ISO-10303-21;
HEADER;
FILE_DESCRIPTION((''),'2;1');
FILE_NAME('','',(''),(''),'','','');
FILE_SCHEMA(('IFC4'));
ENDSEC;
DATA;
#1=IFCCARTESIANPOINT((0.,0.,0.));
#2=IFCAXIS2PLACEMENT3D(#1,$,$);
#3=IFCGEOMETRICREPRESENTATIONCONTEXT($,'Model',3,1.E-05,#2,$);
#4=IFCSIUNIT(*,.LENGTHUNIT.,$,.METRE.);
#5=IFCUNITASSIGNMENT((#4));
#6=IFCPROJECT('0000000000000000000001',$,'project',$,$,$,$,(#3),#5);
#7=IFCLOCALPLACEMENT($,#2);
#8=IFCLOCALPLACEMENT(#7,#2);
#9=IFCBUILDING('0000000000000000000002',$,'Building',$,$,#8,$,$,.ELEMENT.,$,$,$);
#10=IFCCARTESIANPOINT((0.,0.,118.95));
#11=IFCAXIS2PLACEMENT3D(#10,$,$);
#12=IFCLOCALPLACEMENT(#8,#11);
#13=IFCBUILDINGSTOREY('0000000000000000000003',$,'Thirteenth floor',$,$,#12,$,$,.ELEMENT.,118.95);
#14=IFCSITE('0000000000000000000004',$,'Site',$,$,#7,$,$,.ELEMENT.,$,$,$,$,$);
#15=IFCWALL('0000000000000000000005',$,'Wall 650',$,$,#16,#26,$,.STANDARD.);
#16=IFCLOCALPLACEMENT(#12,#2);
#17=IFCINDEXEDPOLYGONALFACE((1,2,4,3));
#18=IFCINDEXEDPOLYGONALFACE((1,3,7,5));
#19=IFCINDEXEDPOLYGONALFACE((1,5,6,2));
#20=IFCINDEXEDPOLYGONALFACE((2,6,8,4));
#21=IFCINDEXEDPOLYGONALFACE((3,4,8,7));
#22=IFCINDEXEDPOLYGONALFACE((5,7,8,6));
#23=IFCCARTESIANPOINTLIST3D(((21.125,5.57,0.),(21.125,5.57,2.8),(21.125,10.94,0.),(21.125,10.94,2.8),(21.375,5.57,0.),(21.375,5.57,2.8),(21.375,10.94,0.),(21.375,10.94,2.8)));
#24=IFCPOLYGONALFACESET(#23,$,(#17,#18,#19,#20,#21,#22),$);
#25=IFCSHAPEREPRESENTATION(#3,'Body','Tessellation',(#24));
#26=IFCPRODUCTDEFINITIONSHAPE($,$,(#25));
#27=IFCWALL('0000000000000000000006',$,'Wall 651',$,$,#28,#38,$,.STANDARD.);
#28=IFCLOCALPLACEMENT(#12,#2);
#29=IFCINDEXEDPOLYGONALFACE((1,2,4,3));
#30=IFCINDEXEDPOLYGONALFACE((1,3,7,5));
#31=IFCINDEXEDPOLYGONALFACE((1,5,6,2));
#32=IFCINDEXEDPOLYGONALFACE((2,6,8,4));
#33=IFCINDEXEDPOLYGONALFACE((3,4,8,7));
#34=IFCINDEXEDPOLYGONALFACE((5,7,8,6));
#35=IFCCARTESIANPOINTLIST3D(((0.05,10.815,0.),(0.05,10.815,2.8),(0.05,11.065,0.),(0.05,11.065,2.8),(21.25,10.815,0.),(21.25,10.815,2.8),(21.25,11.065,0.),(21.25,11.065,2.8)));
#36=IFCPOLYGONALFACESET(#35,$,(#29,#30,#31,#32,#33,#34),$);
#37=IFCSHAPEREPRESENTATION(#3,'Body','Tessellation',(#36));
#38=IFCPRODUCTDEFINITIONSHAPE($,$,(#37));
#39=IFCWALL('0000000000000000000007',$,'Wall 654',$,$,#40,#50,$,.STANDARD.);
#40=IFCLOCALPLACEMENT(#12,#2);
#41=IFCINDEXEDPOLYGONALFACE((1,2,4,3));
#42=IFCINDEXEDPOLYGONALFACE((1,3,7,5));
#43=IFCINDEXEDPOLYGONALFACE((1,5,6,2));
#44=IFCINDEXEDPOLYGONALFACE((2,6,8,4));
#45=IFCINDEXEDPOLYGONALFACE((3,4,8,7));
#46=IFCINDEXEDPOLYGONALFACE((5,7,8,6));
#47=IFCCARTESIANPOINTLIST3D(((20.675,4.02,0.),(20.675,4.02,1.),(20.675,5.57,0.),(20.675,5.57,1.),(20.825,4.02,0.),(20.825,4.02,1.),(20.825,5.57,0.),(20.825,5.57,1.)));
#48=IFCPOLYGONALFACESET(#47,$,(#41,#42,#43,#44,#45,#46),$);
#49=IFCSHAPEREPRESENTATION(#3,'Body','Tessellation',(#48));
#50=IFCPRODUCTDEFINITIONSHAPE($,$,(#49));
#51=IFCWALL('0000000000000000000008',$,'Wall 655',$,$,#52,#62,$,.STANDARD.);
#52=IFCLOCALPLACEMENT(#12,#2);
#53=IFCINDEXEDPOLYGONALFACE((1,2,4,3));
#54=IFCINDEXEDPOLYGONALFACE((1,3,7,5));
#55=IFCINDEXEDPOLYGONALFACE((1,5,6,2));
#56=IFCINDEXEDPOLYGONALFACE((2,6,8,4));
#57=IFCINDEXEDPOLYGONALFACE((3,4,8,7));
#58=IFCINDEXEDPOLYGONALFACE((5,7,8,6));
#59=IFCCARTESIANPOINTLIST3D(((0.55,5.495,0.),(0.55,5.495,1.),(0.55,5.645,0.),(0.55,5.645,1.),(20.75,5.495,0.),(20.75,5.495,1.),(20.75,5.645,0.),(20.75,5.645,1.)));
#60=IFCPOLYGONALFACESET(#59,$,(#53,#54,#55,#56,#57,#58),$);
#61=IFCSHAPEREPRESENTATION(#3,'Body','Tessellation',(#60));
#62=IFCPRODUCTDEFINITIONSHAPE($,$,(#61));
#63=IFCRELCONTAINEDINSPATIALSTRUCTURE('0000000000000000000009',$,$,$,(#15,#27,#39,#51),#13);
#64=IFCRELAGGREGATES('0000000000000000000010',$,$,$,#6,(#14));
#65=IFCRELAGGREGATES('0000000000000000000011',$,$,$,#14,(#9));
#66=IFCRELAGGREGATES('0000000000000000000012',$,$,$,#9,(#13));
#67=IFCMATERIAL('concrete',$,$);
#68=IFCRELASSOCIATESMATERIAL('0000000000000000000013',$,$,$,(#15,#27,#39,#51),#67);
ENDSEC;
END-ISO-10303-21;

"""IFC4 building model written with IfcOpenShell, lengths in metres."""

from ifc_helpers import new_model, si_unit, frame, frame_2d, origin, place, context, project, spatial, rectangle, extrude, material, element, save


model = new_model("IFC4")

# Units and contexts
model_context = context("Model", 3, precision=1e-05, world=origin())
ifc_project = project(units=[si_unit("LENGTHUNIT", "METRE")], contexts=[model_context])

# Site, building, storey
site_placement = place(None, origin())
site = spatial("IfcSite", under=ifc_project, at=site_placement, Name="Site", CompositionType="ELEMENT")
building_placement = place(site_placement, origin())
building = spatial("IfcBuilding", under=site, at=building_placement, Name="Building", CompositionType="ELEMENT")
storey_placement = place(building_placement, frame((0.0, 0.0, 118.95)))
storey = spatial("IfcBuildingStorey", under=building, at=storey_placement, Name="Thirteenth floor", CompositionType="ELEMENT", Elevation=118.95)

# Walls
ifc_material = material(Name="concrete")
wall_1_placement = place(storey_placement, frame((21.25, 5.57, 0.0), z_axis=(0.0, 0.0, 1.0), x_axis=(0.0, 1.0, 0.0)))
element("IfcWall", 1, at=wall_1_placement, inside=storey, material=ifc_material, Name="Wall 650", PredefinedType="STANDARD", context=model_context, shape_type="SweptSolid", body=[
    extrude(rectangle(XDim=5.37, YDim=0.25, at=frame_2d((2.685, 0.0))), origin(), (0.0, 0.0, 1.0), 2.8),
])
wall_2_placement = place(storey_placement, frame((21.25, 10.94, 0.0), z_axis=(0.0, 0.0, 1.0), x_axis=(-1.0, 0.0, 0.0)))
element("IfcWall", 2, at=wall_2_placement, inside=storey, material=ifc_material, Name="Wall 651", PredefinedType="STANDARD", context=model_context, shape_type="SweptSolid", body=[
    extrude(rectangle(XDim=21.2, YDim=0.25, at=frame_2d((10.6, 0.0))), origin(), (0.0, 0.0, 1.0), 2.8),
])
wall_3_placement = place(storey_placement, frame((20.75, 4.02, 0.0), z_axis=(0.0, 0.0, 1.0), x_axis=(0.0, 1.0, 0.0)))
element("IfcWall", 3, at=wall_3_placement, inside=storey, material=ifc_material, Name="Wall 654", PredefinedType="STANDARD", context=model_context, shape_type="SweptSolid", body=[
    extrude(rectangle(XDim=1.55, YDim=0.15, at=frame_2d((0.775, 0.0))), origin(), (0.0, 0.0, 1.0), 1.0),
])
wall_4_placement = place(storey_placement, frame((20.75, 5.57, 0.0), z_axis=(0.0, 0.0, 1.0), x_axis=(-1.0, 0.0, 0.0)))
element("IfcWall", 4, at=wall_4_placement, inside=storey, material=ifc_material, Name="Wall 655", PredefinedType="STANDARD", context=model_context, shape_type="SweptSolid", body=[
    extrude(rectangle(XDim=20.2, YDim=0.15, at=frame_2d((10.1, 0.0))), origin(), (0.0, 0.0, 1.0), 1.0),
])

save(model, "model.ifc")
